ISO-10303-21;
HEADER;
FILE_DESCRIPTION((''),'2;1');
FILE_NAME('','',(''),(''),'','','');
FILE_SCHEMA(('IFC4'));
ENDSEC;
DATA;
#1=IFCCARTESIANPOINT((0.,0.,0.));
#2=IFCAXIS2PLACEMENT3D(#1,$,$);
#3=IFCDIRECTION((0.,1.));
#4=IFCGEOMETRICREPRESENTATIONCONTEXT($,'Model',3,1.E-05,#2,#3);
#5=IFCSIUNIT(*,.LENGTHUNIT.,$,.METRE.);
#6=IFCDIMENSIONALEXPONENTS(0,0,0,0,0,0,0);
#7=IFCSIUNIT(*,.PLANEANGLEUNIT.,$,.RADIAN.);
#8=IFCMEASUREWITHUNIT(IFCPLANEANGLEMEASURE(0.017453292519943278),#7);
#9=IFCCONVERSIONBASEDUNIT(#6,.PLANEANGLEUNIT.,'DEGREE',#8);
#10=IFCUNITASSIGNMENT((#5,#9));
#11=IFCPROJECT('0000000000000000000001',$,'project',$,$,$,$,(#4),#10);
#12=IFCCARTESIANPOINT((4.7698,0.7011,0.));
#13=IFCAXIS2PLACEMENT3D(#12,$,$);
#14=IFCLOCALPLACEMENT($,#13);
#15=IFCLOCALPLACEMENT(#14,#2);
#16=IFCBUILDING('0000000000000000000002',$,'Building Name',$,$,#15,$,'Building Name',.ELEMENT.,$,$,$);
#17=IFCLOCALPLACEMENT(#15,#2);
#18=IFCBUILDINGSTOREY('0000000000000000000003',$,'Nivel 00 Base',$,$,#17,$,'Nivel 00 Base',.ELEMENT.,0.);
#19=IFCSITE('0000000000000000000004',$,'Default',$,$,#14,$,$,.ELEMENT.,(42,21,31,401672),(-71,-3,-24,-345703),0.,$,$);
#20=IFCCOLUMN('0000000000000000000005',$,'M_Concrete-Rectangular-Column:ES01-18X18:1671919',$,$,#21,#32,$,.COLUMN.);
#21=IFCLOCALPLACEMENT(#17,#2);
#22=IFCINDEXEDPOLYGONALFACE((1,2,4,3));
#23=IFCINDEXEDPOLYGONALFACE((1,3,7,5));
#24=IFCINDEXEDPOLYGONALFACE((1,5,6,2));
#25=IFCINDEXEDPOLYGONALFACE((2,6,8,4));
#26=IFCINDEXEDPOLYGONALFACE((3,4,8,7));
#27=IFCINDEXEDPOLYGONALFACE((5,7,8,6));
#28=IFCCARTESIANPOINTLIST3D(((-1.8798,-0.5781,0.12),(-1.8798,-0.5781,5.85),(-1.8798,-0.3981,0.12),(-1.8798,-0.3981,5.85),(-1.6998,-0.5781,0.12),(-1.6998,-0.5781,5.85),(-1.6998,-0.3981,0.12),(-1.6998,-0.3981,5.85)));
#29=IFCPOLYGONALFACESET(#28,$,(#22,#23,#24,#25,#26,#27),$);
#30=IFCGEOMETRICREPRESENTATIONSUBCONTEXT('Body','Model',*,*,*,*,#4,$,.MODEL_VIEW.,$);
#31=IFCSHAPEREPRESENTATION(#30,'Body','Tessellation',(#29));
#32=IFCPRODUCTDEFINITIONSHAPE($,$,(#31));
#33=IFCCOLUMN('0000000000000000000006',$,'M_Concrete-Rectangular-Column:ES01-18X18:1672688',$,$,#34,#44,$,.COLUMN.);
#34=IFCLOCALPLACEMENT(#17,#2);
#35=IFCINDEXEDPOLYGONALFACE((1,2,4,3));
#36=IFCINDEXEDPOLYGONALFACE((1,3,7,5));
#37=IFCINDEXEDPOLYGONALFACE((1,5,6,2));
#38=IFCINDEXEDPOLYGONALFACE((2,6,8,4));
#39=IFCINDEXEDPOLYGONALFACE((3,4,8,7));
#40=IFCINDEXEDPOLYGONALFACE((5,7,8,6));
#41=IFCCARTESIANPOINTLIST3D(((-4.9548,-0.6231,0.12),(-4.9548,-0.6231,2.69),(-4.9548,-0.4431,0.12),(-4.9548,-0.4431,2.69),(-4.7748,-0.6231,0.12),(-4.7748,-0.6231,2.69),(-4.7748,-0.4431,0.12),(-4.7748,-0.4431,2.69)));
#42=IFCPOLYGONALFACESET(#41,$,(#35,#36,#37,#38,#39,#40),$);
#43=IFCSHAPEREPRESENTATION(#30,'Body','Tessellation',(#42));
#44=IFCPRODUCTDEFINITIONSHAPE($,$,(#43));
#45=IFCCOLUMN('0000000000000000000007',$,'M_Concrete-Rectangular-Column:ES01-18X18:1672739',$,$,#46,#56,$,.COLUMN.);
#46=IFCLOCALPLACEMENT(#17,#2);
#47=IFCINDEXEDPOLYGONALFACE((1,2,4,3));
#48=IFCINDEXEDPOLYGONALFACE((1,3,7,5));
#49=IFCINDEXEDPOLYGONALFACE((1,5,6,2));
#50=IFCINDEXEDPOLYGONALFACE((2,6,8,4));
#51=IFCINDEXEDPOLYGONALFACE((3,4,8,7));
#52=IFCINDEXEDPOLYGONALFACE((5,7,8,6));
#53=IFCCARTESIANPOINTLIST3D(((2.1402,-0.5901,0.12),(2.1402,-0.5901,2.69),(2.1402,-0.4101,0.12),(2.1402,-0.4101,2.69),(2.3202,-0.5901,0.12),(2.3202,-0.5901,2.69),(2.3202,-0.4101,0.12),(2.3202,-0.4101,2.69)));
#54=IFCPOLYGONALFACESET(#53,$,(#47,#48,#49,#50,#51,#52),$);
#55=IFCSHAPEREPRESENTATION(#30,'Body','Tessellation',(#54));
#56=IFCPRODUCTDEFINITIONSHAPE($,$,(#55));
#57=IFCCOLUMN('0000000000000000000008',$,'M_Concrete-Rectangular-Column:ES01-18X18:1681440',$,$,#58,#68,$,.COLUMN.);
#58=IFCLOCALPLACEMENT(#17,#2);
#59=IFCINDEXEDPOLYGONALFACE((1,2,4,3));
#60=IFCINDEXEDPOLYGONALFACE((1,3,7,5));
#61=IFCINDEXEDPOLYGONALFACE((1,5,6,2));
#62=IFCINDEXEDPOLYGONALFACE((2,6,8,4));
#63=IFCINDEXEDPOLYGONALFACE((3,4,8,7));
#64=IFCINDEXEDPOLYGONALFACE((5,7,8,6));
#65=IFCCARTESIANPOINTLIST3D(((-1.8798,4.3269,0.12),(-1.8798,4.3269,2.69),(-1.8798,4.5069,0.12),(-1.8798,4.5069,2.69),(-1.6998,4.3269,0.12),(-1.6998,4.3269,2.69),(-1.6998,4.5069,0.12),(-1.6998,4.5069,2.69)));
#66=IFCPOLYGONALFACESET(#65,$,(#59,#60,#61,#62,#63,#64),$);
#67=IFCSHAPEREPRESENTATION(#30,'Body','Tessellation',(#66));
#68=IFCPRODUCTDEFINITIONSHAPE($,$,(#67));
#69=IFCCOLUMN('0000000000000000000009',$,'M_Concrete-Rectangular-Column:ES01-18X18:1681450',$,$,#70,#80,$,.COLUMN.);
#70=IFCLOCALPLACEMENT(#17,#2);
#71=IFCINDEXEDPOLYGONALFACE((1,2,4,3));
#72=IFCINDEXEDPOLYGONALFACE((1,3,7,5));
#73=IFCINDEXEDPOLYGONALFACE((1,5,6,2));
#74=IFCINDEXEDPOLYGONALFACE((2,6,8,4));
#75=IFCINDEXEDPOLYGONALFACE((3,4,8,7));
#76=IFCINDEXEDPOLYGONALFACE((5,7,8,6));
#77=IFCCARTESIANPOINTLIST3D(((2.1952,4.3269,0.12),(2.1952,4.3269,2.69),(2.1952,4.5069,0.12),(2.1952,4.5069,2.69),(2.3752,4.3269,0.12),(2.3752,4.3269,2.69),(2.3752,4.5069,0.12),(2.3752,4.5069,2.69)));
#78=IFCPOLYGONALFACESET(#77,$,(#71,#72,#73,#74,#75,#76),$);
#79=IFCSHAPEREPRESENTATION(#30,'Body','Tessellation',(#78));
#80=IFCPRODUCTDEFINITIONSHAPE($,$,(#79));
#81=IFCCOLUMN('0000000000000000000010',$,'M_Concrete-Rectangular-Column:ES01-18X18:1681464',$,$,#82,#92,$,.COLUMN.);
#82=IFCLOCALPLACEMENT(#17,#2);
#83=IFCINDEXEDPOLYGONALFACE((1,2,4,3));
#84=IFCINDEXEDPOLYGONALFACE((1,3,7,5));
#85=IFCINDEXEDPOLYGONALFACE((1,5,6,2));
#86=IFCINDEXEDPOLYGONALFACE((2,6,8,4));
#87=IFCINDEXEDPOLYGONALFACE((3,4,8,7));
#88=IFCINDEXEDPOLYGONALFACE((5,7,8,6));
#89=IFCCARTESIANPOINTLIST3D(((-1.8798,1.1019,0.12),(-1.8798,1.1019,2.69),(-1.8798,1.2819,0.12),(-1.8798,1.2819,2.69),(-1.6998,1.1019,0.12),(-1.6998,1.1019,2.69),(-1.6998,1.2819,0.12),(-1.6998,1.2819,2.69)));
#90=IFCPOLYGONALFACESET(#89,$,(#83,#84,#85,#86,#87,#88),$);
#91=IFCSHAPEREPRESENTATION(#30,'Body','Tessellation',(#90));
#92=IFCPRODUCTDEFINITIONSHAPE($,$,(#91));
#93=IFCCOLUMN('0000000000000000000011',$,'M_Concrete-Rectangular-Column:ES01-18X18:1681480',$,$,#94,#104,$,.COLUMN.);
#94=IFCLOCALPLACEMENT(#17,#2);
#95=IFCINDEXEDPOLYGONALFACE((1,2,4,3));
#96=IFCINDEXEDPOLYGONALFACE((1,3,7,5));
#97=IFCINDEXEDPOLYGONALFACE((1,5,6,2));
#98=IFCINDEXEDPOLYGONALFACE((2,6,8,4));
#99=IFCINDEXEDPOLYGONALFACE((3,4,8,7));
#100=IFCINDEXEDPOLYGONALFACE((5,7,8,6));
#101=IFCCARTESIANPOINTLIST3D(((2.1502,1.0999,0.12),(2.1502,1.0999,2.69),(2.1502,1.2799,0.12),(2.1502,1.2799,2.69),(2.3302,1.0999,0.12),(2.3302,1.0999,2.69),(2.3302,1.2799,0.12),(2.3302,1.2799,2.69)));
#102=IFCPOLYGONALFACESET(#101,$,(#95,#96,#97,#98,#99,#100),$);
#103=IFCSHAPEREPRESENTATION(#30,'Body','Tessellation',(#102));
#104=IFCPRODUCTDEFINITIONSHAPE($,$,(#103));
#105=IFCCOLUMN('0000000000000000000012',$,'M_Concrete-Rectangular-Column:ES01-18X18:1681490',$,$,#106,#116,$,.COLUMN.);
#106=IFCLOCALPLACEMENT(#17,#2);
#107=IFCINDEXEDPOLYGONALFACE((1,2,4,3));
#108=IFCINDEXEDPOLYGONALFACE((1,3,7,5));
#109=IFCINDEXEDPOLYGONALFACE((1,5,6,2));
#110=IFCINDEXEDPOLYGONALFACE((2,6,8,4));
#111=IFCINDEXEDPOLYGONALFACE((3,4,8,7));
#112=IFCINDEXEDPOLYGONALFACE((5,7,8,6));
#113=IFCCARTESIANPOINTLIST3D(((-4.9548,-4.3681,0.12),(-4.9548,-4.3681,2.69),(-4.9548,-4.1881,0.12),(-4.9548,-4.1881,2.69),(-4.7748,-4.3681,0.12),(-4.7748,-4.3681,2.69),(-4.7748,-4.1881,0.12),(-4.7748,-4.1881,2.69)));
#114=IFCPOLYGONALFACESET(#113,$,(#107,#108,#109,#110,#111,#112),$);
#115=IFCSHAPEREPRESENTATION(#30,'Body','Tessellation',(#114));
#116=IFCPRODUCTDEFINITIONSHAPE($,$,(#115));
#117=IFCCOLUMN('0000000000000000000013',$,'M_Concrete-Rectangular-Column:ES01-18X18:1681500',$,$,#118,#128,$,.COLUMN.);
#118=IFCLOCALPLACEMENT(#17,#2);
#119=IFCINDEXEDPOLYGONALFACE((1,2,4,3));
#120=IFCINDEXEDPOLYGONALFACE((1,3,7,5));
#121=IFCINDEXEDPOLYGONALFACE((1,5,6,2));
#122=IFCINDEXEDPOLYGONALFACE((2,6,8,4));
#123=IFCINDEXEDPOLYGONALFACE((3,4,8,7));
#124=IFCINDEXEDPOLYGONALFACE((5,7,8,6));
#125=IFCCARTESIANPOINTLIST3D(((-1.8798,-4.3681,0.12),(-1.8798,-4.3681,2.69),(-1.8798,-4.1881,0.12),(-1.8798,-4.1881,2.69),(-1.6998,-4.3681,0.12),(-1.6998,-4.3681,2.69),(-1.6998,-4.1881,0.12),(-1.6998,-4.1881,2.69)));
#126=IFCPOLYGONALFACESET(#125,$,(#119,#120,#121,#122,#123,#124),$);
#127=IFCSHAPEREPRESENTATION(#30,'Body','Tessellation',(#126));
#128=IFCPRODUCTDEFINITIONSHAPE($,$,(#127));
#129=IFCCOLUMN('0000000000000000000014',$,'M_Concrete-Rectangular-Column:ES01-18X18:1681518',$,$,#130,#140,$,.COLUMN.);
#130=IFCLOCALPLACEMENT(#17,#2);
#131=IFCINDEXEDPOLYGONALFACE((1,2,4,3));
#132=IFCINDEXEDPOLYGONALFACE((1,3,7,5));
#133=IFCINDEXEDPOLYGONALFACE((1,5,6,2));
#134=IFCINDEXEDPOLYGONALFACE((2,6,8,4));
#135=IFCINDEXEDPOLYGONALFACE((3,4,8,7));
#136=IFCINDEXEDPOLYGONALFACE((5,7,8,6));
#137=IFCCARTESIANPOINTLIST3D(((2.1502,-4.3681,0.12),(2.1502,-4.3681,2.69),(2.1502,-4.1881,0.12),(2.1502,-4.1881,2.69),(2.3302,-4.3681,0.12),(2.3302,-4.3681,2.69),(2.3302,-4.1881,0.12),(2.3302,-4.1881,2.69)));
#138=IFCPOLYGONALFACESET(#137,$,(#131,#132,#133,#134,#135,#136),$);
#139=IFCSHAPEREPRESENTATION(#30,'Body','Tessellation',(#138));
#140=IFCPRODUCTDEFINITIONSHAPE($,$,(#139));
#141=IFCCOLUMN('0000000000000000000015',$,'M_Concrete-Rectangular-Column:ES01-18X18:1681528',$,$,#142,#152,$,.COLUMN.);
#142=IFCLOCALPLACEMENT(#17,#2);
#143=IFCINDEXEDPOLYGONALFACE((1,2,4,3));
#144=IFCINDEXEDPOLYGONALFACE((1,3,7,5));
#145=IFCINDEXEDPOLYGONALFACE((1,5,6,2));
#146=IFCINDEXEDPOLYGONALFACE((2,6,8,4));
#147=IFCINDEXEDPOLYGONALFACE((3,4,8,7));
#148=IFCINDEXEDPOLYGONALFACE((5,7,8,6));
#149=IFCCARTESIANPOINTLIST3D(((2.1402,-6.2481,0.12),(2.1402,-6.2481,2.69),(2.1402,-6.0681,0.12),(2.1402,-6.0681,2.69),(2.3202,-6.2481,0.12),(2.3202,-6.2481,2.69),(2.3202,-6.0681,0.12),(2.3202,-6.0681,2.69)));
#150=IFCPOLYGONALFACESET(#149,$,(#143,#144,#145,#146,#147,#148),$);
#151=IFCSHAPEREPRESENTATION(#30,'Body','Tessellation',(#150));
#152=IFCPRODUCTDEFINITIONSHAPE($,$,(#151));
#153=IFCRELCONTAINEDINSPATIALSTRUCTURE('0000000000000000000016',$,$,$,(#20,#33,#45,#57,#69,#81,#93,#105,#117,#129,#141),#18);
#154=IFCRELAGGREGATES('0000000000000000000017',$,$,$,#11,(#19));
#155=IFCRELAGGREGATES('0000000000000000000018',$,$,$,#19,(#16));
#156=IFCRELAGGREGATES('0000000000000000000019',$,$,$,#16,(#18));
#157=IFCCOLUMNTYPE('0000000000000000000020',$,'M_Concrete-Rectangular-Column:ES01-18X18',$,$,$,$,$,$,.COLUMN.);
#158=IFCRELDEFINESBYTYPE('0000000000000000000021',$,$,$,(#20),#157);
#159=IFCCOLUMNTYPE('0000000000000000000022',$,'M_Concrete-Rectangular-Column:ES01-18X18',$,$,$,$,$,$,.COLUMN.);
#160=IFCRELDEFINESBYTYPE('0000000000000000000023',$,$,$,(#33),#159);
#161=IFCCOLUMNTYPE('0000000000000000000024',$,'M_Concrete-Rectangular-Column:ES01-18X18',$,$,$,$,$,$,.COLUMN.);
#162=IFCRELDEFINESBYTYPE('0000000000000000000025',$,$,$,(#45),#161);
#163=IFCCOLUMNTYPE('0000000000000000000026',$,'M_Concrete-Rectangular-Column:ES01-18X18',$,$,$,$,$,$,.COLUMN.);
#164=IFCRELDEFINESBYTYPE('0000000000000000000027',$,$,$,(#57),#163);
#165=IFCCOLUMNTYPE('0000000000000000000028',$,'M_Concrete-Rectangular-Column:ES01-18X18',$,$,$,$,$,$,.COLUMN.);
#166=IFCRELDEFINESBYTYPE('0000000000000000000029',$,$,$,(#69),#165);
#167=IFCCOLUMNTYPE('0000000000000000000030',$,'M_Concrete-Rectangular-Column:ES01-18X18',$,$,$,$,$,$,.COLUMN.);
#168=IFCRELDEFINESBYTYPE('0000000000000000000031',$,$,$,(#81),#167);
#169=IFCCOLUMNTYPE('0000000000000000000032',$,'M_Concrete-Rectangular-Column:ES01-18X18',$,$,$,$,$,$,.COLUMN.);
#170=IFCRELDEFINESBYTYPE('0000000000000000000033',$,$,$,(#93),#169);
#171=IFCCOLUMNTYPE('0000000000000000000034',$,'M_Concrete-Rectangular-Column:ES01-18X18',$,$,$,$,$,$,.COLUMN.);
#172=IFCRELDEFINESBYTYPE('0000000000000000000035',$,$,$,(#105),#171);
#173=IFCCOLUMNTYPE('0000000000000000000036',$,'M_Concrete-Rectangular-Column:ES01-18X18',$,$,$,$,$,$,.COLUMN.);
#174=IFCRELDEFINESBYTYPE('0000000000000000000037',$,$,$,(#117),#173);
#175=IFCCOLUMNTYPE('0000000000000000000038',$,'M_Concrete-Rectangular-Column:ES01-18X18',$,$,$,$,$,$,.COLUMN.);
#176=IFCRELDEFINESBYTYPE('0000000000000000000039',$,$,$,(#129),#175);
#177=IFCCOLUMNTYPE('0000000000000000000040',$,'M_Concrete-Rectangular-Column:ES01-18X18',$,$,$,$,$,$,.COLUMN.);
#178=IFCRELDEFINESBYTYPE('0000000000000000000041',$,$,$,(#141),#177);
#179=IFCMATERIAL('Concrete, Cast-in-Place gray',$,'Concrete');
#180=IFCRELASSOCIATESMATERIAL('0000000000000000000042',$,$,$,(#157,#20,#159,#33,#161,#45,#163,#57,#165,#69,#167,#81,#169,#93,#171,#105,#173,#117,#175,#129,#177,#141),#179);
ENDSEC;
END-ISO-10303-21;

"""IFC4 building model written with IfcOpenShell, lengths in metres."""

from ifc_helpers import new_model, entity, si_unit, converted_unit, direction, frame, origin, place, context, subcontext, project, spatial, indexed_curve, outline, extrude, source, transform, mapped, material, type_object, type_shapes, element, save


model = new_model("IFC4")

# Units and contexts
model_context = context("Model", 3, precision=1e-05, world=origin(), true_north=direction((0.0, 1.0)))
body_context = subcontext(model_context, "Body", "Model", "MODEL_VIEW")
ifc_project = project(units=[si_unit("LENGTHUNIT", "METRE"), converted_unit("PLANEANGLEUNIT", "DEGREE", entity("IfcPlaneAngleMeasure", 0.017453292519943278), si_unit("PLANEANGLEUNIT", "RADIAN"), dimensions=[0, 0, 0, 0, 0, 0, 0])], contexts=[model_context])

# Site, building, storey
site_placement = place(None, frame((4.7698, 0.7011, 0.0)))
site = spatial("IfcSite", under=ifc_project, at=site_placement, Name="Default", CompositionType="ELEMENT", RefLatitude=(42, 21, 31, 401672), RefLongitude=(-71, -3, -24, -345703), RefElevation=0.0)
building_placement = place(site_placement, origin())
building = spatial("IfcBuilding", under=site, at=building_placement, Name="Building Name", LongName="Building Name", CompositionType="ELEMENT")
storey_placement = place(building_placement, origin())
storey = spatial("IfcBuildingStorey", under=building, at=storey_placement, Name="Nivel 00 Base", LongName="Nivel 00 Base", CompositionType="ELEMENT", Elevation=0.0)

# Columns
ifc_material_1 = material(Name="Concrete, Cast-in-Place gray", Category="Concrete")
column_type_1 = type_object("IfcColumnType", Name="M_Concrete-Rectangular-Column:ES01-18X18", PredefinedType="COLUMN", material=ifc_material_1)
shared_shape_1 = source(origin(), body_context, "Body", "SweptSolid", [
    extrude(outline(indexed_curve([(-0.09, -0.09), (0.09, -0.09), (0.09, 0.09), (-0.09, 0.09), (-0.09, -0.09)], self_intersect=False)), frame((-1.7898, -0.4881, 0.12), z_axis=(0.0, 0.0, 1.0), x_axis=(-1.0, 0.0, 0.0)), (0.0, 0.0, 1.0), 5.73),
])
type_shapes(column_type_1, [shared_shape_1])
column_1_placement = place(storey_placement, origin())
element("IfcColumn", 1, at=column_1_placement, inside=storey, type_object=column_type_1, material=ifc_material_1, Name="M_Concrete-Rectangular-Column:ES01-18X18:1671919", PredefinedType="COLUMN", context=body_context, shape_type="MappedRepresentation", body=[
    mapped(shared_shape_1, transform((0.0, 0.0, 0.0), scale=1.0)),
])
column_type_2 = type_object("IfcColumnType", Name="M_Concrete-Rectangular-Column:ES01-18X18", PredefinedType="COLUMN", material=ifc_material_1)
shared_shape_2 = source(origin(), body_context, "Body", "SweptSolid", [
    extrude(outline(indexed_curve([(-0.09, -0.09), (0.09, -0.09), (0.09, 0.09), (-0.09, 0.09), (-0.09, -0.09)], self_intersect=False)), frame((-4.8648, -0.5331, 0.12), z_axis=(0.0, 0.0, 1.0), x_axis=(-1.0, 0.0, 0.0)), (0.0, 0.0, 1.0), 2.57),
])
type_shapes(column_type_2, [shared_shape_2])
column_2_placement = place(storey_placement, origin())
element("IfcColumn", 2, at=column_2_placement, inside=storey, type_object=column_type_2, material=ifc_material_1, Name="M_Concrete-Rectangular-Column:ES01-18X18:1672688", PredefinedType="COLUMN", context=body_context, shape_type="MappedRepresentation", body=[
    mapped(shared_shape_2, transform((0.0, 0.0, 0.0), scale=1.0)),
])
column_type_3 = type_object("IfcColumnType", Name="M_Concrete-Rectangular-Column:ES01-18X18", PredefinedType="COLUMN", material=ifc_material_1)
shared_shape_3 = source(origin(), body_context, "Body", "SweptSolid", [
    extrude(outline(indexed_curve([(-0.09, -0.09), (0.09, -0.09), (0.09, 0.09), (-0.09, 0.09), (-0.09, -0.09)], self_intersect=False)), frame((2.2302, -0.5001, 0.12), z_axis=(0.0, 0.0, 1.0), x_axis=(-1.0, 0.0, 0.0)), (0.0, 0.0, 1.0), 2.57),
])
type_shapes(column_type_3, [shared_shape_3])
column_3_placement = place(storey_placement, origin())
element("IfcColumn", 3, at=column_3_placement, inside=storey, type_object=column_type_3, material=ifc_material_1, Name="M_Concrete-Rectangular-Column:ES01-18X18:1672739", PredefinedType="COLUMN", context=body_context, shape_type="MappedRepresentation", body=[
    mapped(shared_shape_3, transform((0.0, 0.0, 0.0), scale=1.0)),
])
column_type_4 = type_object("IfcColumnType", Name="M_Concrete-Rectangular-Column:ES01-18X18", PredefinedType="COLUMN", material=ifc_material_1)
shared_shape_4 = source(origin(), body_context, "Body", "SweptSolid", [
    extrude(outline(indexed_curve([(-0.09, -0.09), (0.09, -0.09), (0.09, 0.09), (-0.09, 0.09), (-0.09, -0.09)], self_intersect=False)), frame((-1.7898, 4.4169, 0.12), z_axis=(0.0, 0.0, 1.0), x_axis=(-1.0, 0.0, 0.0)), (0.0, 0.0, 1.0), 2.57),
])
type_shapes(column_type_4, [shared_shape_4])
column_4_placement = place(storey_placement, origin())
element("IfcColumn", 4, at=column_4_placement, inside=storey, type_object=column_type_4, material=ifc_material_1, Name="M_Concrete-Rectangular-Column:ES01-18X18:1681440", PredefinedType="COLUMN", context=body_context, shape_type="MappedRepresentation", body=[
    mapped(shared_shape_4, transform((0.0, 0.0, 0.0), scale=1.0)),
])
column_type_5 = type_object("IfcColumnType", Name="M_Concrete-Rectangular-Column:ES01-18X18", PredefinedType="COLUMN", material=ifc_material_1)
shared_shape_5 = source(origin(), body_context, "Body", "SweptSolid", [
    extrude(outline(indexed_curve([(-0.09, -0.09), (0.09, -0.09), (0.09, 0.09), (-0.09, 0.09), (-0.09, -0.09)], self_intersect=False)), frame((2.2852, 4.4169, 0.12), z_axis=(0.0, 0.0, 1.0), x_axis=(-1.0, 0.0, 0.0)), (0.0, 0.0, 1.0), 2.57),
])
type_shapes(column_type_5, [shared_shape_5])
column_5_placement = place(storey_placement, origin())
element("IfcColumn", 5, at=column_5_placement, inside=storey, type_object=column_type_5, material=ifc_material_1, Name="M_Concrete-Rectangular-Column:ES01-18X18:1681450", PredefinedType="COLUMN", context=body_context, shape_type="MappedRepresentation", body=[
    mapped(shared_shape_5, transform((0.0, 0.0, 0.0), scale=1.0)),
])
column_type_6 = type_object("IfcColumnType", Name="M_Concrete-Rectangular-Column:ES01-18X18", PredefinedType="COLUMN", material=ifc_material_1)
shared_shape_6 = source(origin(), body_context, "Body", "SweptSolid", [
    extrude(outline(indexed_curve([(-0.09, -0.09), (0.09, -0.09), (0.09, 0.09), (-0.09, 0.09), (-0.09, -0.09)], self_intersect=False)), frame((-1.7898, 1.1919, 0.12), z_axis=(0.0, 0.0, 1.0), x_axis=(-1.0, 0.0, 0.0)), (0.0, 0.0, 1.0), 2.57),
])
type_shapes(column_type_6, [shared_shape_6])
column_6_placement = place(storey_placement, origin())
element("IfcColumn", 6, at=column_6_placement, inside=storey, type_object=column_type_6, material=ifc_material_1, Name="M_Concrete-Rectangular-Column:ES01-18X18:1681464", PredefinedType="COLUMN", context=body_context, shape_type="MappedRepresentation", body=[
    mapped(shared_shape_6, transform((0.0, 0.0, 0.0), scale=1.0)),
])
column_type_7 = type_object("IfcColumnType", Name="M_Concrete-Rectangular-Column:ES01-18X18", PredefinedType="COLUMN", material=ifc_material_1)
shared_shape_7 = source(origin(), body_context, "Body", "SweptSolid", [
    extrude(outline(indexed_curve([(-0.09, -0.09), (0.09, -0.09), (0.09, 0.09), (-0.09, 0.09), (-0.09, -0.09)], self_intersect=False)), frame((2.2402, 1.1899, 0.12), z_axis=(0.0, 0.0, 1.0), x_axis=(-1.0, 0.0, 0.0)), (0.0, 0.0, 1.0), 2.57),
])
type_shapes(column_type_7, [shared_shape_7])
column_7_placement = place(storey_placement, origin())
element("IfcColumn", 7, at=column_7_placement, inside=storey, type_object=column_type_7, material=ifc_material_1, Name="M_Concrete-Rectangular-Column:ES01-18X18:1681480", PredefinedType="COLUMN", context=body_context, shape_type="MappedRepresentation", body=[
    mapped(shared_shape_7, transform((0.0, 0.0, 0.0), scale=1.0)),
])
column_type_8 = type_object("IfcColumnType", Name="M_Concrete-Rectangular-Column:ES01-18X18", PredefinedType="COLUMN", material=ifc_material_1)
shared_shape_8 = source(origin(), body_context, "Body", "SweptSolid", [
    extrude(outline(indexed_curve([(-0.09, -0.09), (0.09, -0.09), (0.09, 0.09), (-0.09, 0.09), (-0.09, -0.09)], self_intersect=False)), frame((-4.8648, -4.2781, 0.12), z_axis=(0.0, 0.0, 1.0), x_axis=(-1.0, 0.0, 0.0)), (0.0, 0.0, 1.0), 2.57),
])
type_shapes(column_type_8, [shared_shape_8])
column_8_placement = place(storey_placement, origin())
element("IfcColumn", 8, at=column_8_placement, inside=storey, type_object=column_type_8, material=ifc_material_1, Name="M_Concrete-Rectangular-Column:ES01-18X18:1681490", PredefinedType="COLUMN", context=body_context, shape_type="MappedRepresentation", body=[
    mapped(shared_shape_8, transform((0.0, 0.0, 0.0), scale=1.0)),
])
column_type_9 = type_object("IfcColumnType", Name="M_Concrete-Rectangular-Column:ES01-18X18", PredefinedType="COLUMN", material=ifc_material_1)
shared_shape_9 = source(origin(), body_context, "Body", "SweptSolid", [
    extrude(outline(indexed_curve([(-0.09, -0.09), (0.09, -0.09), (0.09, 0.09), (-0.09, 0.09), (-0.09, -0.09)], self_intersect=False)), frame((-1.7898, -4.2781, 0.12), z_axis=(0.0, 0.0, 1.0), x_axis=(-1.0, 0.0, 0.0)), (0.0, 0.0, 1.0), 2.57),
])
type_shapes(column_type_9, [shared_shape_9])
column_9_placement = place(storey_placement, origin())
element("IfcColumn", 9, at=column_9_placement, inside=storey, type_object=column_type_9, material=ifc_material_1, Name="M_Concrete-Rectangular-Column:ES01-18X18:1681500", PredefinedType="COLUMN", context=body_context, shape_type="MappedRepresentation", body=[
    mapped(shared_shape_9, transform((0.0, 0.0, 0.0), scale=1.0)),
])
column_type_10 = type_object("IfcColumnType", Name="M_Concrete-Rectangular-Column:ES01-18X18", PredefinedType="COLUMN", material=ifc_material_1)
shared_shape_10 = source(origin(), body_context, "Body", "SweptSolid", [
    extrude(outline(indexed_curve([(-0.09, -0.09), (0.09, -0.09), (0.09, 0.09), (-0.09, 0.09), (-0.09, -0.09)], self_intersect=False)), frame((2.2402, -4.2781, 0.12), z_axis=(0.0, 0.0, 1.0), x_axis=(-1.0, 0.0, 0.0)), (0.0, 0.0, 1.0), 2.57),
])
type_shapes(column_type_10, [shared_shape_10])
column_10_placement = place(storey_placement, origin())
element("IfcColumn", 10, at=column_10_placement, inside=storey, type_object=column_type_10, material=ifc_material_1, Name="M_Concrete-Rectangular-Column:ES01-18X18:1681518", PredefinedType="COLUMN", context=body_context, shape_type="MappedRepresentation", body=[
    mapped(shared_shape_10, transform((0.0, 0.0, 0.0), scale=1.0)),
])
column_type_11 = type_object("IfcColumnType", Name="M_Concrete-Rectangular-Column:ES01-18X18", PredefinedType="COLUMN", material=ifc_material_1)
shared_shape_11 = source(origin(), body_context, "Body", "SweptSolid", [
    extrude(outline(indexed_curve([(-0.09, -0.09), (0.09, -0.09), (0.09, 0.09), (-0.09, 0.09), (-0.09, -0.09)], self_intersect=False)), frame((2.2302, -6.1581, 0.12), z_axis=(0.0, 0.0, 1.0), x_axis=(-1.0, 0.0, 0.0)), (0.0, 0.0, 1.0), 2.57),
])
type_shapes(column_type_11, [shared_shape_11])
column_11_placement = place(storey_placement, origin())
element("IfcColumn", 11, at=column_11_placement, inside=storey, type_object=column_type_11, material=ifc_material_1, Name="M_Concrete-Rectangular-Column:ES01-18X18:1681528", PredefinedType="COLUMN", context=body_context, shape_type="MappedRepresentation", body=[
    mapped(shared_shape_11, transform((0.0, 0.0, 0.0), scale=1.0)),
])

save(model, "model.ifc")
